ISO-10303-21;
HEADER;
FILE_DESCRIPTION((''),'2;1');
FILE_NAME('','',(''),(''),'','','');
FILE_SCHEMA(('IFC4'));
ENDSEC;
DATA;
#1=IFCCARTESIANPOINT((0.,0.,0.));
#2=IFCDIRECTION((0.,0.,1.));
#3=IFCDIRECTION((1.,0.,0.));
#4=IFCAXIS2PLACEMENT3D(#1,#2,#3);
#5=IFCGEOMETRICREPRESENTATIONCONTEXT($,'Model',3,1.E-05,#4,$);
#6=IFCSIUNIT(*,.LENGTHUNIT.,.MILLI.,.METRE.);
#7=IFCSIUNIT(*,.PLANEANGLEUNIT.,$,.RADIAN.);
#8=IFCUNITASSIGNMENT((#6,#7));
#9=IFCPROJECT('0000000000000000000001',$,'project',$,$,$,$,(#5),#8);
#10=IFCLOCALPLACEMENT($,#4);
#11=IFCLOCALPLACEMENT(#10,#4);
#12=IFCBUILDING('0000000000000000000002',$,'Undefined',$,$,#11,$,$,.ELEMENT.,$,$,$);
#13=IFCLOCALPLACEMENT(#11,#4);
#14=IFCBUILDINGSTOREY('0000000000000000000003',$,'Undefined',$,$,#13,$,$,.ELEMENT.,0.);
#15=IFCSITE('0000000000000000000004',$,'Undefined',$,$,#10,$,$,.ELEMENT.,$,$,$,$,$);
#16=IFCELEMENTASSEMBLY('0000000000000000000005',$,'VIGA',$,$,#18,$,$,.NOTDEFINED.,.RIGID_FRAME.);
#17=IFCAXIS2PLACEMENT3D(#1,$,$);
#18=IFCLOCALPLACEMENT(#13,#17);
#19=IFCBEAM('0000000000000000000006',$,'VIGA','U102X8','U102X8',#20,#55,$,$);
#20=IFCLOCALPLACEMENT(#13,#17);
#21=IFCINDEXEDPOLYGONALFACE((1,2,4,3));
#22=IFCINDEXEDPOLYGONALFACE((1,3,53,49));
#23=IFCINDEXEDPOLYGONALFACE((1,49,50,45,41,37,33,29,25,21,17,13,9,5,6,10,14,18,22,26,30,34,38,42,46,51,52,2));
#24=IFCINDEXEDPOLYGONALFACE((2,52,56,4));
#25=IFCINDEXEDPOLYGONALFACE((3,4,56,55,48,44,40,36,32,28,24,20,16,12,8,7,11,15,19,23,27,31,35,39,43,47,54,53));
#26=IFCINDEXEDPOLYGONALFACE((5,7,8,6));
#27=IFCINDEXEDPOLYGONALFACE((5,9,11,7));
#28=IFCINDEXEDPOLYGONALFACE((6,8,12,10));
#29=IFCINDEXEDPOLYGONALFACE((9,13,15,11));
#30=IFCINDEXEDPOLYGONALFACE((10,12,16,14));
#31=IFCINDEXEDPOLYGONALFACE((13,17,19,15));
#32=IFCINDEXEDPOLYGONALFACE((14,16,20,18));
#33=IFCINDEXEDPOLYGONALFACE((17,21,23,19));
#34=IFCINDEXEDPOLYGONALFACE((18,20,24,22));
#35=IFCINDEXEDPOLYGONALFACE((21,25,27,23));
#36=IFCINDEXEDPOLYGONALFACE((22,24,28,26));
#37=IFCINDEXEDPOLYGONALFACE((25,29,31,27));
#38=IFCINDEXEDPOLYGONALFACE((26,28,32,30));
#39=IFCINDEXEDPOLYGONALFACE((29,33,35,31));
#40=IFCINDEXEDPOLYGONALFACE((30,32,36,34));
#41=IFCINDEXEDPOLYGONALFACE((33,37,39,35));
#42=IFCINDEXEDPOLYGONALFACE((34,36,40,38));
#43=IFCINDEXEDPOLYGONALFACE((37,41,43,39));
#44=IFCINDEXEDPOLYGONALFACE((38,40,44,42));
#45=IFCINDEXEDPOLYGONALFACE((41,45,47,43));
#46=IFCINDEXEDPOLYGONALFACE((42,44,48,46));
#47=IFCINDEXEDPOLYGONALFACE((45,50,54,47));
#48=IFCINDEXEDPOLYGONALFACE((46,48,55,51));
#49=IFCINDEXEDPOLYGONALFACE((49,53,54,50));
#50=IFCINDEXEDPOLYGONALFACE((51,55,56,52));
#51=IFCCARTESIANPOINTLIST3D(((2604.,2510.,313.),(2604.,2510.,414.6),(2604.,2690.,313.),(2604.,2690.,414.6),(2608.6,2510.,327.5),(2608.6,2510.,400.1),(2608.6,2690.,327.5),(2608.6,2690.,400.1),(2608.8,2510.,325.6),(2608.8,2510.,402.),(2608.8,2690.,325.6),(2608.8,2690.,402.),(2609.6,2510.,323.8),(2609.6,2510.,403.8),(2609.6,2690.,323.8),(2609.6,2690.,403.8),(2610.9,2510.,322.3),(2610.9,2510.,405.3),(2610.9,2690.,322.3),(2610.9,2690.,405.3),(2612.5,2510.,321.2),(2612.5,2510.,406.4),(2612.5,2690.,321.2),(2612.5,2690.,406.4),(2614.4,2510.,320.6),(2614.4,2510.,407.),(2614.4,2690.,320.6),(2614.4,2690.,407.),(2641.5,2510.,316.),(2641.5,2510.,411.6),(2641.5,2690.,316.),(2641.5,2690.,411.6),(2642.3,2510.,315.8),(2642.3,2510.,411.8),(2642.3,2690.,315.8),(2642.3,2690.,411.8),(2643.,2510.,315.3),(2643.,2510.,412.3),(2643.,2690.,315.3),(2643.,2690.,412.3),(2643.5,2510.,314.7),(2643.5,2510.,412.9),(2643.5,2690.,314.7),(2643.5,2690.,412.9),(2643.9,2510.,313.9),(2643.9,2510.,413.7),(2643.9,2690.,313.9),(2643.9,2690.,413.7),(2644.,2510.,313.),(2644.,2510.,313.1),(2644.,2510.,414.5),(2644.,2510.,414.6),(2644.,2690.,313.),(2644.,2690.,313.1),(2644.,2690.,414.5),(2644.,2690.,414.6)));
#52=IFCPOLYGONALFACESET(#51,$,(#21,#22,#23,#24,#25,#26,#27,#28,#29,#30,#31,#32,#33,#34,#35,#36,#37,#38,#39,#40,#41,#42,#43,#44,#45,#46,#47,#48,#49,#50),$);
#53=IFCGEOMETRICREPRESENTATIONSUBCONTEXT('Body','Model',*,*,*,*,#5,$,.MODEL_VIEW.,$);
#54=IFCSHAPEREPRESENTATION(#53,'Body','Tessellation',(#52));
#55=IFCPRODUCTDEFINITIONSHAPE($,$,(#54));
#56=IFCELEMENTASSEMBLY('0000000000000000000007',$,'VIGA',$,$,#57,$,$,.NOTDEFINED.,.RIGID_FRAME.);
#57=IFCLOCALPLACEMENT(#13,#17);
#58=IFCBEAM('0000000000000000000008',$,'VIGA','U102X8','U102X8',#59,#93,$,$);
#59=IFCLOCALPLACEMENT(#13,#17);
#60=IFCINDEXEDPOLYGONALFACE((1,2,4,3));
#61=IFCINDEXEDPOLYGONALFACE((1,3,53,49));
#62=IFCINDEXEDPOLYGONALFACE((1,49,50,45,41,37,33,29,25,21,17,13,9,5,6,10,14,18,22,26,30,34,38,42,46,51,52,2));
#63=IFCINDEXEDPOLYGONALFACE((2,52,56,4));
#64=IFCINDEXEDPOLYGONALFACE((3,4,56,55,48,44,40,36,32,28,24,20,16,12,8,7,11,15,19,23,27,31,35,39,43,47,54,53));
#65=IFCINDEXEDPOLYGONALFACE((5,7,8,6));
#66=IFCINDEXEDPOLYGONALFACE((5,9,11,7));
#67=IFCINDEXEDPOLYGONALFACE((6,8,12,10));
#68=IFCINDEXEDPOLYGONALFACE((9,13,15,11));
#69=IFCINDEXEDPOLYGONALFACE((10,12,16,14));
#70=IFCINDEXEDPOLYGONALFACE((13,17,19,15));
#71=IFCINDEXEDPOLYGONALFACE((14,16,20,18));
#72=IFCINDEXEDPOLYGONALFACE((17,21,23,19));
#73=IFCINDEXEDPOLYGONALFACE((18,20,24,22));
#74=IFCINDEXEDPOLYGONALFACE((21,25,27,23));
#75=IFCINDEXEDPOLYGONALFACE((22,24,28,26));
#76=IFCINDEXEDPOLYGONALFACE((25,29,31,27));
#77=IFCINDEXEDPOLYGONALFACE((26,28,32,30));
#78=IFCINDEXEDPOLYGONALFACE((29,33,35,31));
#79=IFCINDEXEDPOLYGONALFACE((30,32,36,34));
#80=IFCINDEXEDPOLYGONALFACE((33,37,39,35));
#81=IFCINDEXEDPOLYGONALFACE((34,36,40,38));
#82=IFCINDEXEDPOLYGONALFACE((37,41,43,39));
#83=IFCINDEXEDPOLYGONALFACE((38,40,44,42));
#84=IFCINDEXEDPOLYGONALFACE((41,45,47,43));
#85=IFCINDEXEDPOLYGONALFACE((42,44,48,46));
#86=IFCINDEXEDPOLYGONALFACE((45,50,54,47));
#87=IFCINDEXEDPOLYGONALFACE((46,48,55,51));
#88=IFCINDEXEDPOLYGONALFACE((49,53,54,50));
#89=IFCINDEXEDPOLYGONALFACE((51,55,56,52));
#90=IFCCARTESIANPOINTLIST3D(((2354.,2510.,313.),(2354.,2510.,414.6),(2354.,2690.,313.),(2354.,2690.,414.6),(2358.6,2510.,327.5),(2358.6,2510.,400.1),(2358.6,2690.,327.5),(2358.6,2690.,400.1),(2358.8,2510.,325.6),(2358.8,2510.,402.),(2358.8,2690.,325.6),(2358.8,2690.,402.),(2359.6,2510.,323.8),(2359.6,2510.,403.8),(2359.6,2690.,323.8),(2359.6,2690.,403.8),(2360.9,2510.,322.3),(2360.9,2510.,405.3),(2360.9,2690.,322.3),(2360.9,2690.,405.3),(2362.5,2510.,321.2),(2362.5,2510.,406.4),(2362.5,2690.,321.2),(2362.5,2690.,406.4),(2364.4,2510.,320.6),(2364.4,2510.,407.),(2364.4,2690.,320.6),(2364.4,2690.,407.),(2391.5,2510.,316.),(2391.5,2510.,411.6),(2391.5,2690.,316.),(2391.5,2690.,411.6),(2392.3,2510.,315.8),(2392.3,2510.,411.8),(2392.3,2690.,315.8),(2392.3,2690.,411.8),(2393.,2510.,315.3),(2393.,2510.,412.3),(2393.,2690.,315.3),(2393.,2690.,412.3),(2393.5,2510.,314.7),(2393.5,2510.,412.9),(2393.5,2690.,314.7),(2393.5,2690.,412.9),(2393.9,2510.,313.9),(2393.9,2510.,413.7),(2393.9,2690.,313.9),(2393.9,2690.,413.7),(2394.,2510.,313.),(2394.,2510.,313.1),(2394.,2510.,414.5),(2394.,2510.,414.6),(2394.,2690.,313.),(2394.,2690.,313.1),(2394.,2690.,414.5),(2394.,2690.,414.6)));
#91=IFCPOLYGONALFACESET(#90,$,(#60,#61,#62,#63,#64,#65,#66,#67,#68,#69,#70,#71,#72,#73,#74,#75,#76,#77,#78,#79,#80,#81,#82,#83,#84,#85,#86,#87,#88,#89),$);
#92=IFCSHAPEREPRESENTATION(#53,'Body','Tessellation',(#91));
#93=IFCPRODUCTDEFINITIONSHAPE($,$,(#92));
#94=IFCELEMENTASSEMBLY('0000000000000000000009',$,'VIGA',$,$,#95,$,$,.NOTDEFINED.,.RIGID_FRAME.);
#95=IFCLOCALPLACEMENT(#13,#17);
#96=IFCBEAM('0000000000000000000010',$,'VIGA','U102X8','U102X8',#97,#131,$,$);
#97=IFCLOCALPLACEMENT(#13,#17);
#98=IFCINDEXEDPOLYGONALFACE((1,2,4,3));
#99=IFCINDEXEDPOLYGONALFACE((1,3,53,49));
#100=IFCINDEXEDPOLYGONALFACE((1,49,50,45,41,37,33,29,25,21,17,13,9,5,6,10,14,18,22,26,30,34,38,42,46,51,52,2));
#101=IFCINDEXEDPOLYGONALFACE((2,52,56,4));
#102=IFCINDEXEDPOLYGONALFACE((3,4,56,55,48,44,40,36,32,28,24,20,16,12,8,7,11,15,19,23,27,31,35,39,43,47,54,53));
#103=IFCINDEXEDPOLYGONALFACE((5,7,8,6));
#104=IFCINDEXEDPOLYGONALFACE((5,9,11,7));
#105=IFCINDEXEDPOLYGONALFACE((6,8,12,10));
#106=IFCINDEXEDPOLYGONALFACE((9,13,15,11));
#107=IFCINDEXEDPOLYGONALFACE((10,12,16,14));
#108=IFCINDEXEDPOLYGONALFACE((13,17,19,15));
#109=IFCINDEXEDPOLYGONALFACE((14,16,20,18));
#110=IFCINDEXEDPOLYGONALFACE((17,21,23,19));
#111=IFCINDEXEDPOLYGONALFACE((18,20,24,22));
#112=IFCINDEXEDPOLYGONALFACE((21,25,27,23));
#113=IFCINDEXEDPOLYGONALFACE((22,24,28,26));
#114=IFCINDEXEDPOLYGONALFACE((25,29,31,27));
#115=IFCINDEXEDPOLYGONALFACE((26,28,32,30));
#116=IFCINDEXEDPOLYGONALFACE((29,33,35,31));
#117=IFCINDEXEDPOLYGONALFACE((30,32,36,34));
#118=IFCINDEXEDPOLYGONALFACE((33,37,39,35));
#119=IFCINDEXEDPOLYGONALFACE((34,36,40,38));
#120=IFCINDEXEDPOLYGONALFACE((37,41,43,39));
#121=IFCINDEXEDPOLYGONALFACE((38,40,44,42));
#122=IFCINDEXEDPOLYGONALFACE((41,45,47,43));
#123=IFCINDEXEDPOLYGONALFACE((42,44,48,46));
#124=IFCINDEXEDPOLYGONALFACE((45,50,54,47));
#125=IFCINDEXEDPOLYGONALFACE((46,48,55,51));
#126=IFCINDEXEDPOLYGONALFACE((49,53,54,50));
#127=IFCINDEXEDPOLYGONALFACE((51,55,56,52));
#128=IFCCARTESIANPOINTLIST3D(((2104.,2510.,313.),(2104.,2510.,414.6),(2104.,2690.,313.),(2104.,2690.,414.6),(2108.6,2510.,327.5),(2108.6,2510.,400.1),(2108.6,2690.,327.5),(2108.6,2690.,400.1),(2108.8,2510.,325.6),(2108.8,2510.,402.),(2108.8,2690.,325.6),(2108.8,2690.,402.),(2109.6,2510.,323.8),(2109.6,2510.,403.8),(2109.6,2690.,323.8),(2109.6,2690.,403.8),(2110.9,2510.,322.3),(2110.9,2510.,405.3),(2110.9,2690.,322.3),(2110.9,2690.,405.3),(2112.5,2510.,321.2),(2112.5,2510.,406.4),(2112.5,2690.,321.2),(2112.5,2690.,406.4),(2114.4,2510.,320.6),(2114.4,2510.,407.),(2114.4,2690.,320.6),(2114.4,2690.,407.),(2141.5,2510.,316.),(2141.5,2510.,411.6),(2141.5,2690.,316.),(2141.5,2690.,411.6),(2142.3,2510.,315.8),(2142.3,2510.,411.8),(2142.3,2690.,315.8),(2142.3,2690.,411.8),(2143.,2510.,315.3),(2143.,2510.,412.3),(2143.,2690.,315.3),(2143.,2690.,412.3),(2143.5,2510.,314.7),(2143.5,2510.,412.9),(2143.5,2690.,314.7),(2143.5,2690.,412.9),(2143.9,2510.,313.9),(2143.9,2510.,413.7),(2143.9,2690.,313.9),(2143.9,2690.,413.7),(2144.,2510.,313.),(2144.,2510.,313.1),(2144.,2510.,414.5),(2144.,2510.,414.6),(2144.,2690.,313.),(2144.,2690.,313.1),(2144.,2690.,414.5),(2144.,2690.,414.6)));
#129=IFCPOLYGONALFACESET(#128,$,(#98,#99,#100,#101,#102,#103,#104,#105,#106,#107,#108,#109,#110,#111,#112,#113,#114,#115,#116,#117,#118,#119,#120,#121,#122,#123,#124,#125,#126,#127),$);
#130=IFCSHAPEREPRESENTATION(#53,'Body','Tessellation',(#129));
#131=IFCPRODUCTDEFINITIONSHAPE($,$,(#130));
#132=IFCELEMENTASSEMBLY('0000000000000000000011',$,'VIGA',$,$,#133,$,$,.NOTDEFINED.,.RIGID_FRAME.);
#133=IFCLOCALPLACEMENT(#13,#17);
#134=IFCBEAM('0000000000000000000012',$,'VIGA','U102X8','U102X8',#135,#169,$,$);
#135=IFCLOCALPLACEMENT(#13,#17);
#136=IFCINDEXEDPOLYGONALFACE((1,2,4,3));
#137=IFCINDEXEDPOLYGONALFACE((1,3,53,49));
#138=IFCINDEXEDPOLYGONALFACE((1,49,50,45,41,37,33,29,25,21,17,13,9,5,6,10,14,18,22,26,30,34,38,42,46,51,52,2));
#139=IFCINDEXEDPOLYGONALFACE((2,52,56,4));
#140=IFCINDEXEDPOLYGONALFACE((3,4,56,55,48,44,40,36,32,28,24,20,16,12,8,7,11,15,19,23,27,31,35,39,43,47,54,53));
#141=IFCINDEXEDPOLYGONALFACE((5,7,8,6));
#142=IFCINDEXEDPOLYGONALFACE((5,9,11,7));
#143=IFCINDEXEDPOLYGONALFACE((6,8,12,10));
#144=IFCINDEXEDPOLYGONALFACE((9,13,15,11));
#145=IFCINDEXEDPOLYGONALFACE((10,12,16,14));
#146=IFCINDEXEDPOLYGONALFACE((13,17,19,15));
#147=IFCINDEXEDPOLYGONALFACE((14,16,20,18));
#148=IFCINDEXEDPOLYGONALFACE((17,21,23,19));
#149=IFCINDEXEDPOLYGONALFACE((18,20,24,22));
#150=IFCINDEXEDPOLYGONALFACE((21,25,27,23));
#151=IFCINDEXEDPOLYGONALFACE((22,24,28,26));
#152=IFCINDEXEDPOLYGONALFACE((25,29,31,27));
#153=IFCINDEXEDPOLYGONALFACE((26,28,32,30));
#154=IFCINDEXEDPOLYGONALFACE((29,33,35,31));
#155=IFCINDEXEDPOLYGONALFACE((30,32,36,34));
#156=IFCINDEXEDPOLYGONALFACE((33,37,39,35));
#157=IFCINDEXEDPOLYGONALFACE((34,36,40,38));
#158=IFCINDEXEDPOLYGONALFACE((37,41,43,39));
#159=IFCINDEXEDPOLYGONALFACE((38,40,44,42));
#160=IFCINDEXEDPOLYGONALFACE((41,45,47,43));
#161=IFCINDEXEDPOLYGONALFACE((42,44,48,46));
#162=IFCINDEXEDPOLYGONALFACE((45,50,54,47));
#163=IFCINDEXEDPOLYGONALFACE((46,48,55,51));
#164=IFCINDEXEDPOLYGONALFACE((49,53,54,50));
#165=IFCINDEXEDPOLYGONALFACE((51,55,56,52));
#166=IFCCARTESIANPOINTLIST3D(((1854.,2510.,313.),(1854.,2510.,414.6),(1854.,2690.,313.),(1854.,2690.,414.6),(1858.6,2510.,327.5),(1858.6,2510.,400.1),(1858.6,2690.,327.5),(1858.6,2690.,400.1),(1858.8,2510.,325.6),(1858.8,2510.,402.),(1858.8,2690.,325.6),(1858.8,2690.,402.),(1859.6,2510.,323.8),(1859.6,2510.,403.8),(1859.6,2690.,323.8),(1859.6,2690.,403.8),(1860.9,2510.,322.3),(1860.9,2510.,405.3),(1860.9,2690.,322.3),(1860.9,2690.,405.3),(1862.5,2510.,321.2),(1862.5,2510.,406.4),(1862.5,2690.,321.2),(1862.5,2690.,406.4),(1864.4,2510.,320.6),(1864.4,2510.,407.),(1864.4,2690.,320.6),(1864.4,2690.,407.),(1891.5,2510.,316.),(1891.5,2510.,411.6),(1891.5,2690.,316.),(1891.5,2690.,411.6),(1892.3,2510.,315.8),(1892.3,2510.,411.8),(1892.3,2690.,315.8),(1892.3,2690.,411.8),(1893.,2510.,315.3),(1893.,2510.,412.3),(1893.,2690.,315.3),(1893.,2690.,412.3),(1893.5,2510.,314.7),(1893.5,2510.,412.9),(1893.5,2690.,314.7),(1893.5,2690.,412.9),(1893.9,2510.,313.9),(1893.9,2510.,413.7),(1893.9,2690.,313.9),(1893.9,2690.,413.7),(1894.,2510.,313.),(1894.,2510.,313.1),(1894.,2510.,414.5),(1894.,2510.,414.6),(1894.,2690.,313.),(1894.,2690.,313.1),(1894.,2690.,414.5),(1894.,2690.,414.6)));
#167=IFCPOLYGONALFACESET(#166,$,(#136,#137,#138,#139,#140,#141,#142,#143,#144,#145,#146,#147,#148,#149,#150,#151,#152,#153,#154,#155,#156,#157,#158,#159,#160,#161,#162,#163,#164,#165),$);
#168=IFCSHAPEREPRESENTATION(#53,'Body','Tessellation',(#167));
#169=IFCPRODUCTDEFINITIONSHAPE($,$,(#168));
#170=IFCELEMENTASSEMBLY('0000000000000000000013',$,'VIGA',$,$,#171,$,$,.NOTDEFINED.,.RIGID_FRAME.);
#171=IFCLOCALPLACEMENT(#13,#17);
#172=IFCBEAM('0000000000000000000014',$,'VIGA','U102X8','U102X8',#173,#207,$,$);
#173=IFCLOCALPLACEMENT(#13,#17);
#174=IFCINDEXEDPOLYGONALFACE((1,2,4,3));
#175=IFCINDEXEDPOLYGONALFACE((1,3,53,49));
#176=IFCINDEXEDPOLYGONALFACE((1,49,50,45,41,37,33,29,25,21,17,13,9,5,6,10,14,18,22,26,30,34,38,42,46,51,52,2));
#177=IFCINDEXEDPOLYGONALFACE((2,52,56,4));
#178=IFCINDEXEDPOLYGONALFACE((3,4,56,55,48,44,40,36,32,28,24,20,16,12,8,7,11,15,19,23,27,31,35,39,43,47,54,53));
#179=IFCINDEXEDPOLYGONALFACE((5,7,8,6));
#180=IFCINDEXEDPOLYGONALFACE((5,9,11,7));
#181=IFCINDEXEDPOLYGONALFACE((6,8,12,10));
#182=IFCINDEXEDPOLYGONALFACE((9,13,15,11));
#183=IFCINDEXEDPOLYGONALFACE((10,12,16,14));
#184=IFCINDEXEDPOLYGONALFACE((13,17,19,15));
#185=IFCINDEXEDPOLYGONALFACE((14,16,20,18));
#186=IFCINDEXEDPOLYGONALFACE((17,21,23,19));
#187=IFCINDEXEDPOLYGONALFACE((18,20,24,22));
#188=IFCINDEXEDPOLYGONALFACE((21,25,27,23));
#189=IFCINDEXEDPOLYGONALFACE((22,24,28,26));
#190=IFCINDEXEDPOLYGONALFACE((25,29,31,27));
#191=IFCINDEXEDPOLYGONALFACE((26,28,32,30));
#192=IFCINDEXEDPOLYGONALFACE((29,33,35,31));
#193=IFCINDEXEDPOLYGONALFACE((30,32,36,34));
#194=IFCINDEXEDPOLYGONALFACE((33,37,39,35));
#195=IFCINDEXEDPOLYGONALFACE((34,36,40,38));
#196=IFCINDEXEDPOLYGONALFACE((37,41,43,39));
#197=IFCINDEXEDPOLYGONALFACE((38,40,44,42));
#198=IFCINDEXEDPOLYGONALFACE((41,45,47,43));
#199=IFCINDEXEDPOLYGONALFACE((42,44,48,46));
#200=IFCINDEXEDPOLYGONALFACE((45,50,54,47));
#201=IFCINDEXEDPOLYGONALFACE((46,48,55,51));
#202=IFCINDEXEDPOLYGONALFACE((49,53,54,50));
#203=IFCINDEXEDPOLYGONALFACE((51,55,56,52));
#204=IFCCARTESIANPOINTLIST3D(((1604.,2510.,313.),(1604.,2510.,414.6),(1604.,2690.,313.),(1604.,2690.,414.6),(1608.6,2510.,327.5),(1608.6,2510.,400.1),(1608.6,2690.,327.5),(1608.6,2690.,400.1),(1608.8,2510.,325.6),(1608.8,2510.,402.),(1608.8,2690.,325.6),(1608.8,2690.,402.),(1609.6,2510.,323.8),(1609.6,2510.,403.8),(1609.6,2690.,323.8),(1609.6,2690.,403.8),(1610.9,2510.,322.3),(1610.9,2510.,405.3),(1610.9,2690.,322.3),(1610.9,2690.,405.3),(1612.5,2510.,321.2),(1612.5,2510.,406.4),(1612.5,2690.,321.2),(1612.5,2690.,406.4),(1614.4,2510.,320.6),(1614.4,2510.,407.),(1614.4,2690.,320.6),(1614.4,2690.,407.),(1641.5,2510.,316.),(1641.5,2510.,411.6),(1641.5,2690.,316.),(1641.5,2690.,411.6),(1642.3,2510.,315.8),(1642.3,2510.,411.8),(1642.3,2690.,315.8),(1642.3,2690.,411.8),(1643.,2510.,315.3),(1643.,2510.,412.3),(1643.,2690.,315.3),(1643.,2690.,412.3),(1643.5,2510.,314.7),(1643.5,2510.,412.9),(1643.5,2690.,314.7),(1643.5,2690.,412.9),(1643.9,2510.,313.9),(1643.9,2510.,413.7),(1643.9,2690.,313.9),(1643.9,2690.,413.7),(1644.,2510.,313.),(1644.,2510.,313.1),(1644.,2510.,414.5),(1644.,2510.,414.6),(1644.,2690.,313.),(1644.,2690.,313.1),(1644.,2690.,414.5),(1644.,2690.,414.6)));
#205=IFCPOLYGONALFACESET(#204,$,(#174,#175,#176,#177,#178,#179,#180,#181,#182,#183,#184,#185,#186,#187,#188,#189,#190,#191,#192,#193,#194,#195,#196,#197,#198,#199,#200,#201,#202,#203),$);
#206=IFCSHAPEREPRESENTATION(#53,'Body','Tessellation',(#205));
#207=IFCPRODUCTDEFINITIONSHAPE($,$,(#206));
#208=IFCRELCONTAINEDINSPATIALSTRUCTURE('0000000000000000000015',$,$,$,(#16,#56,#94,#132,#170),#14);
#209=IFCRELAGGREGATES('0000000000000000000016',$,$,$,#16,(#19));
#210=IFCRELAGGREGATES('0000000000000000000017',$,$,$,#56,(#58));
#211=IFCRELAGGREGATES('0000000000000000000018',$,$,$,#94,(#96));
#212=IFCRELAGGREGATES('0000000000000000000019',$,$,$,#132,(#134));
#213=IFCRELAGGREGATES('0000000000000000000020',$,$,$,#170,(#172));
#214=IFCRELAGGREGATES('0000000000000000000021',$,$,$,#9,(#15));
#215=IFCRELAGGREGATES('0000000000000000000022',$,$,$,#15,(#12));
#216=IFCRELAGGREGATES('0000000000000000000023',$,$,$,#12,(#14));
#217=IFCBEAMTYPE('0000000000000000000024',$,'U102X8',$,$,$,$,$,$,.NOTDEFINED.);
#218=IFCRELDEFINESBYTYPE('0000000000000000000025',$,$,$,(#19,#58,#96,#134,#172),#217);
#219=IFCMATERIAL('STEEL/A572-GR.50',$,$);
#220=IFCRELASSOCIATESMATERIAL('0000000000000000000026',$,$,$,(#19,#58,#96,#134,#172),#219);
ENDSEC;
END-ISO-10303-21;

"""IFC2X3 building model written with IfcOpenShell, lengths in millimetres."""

from ifc_helpers import new_model, si_unit, frame, origin_with_axes, origin_2d_with_axis, place, context, subcontext, project, spatial, u_section, extrude, material, type_object, element, aggregate, save


model = new_model("IFC2X3")

# Units and contexts
model_context = context("Model", 3, precision=1e-05, world=origin_with_axes())
body_context = subcontext(model_context, "Body", "Model", "MODEL_VIEW")
ifc_project = project(units=[si_unit("LENGTHUNIT", "METRE", prefix="MILLI"), si_unit("PLANEANGLEUNIT", "RADIAN")], contexts=[model_context])

# Site, building, storey
site_placement = place(None, origin_with_axes())
site = spatial("IfcSite", under=ifc_project, at=site_placement, Name="Undefined", CompositionType="ELEMENT")
building_placement = place(site_placement, origin_with_axes())
building = spatial("IfcBuilding", under=site, at=building_placement, Name="Undefined", CompositionType="ELEMENT")
storey_placement = place(building_placement, origin_with_axes())
storey = spatial("IfcBuildingStorey", under=building, at=storey_placement, Name="Undefined", CompositionType="ELEMENT", Elevation=0.0)

# Element assemblies, beams
ifc_material = material(Name="STEEL/A572-GR.50")
beam_type = type_object("IfcBeamType", Name="U102X8", PredefinedType="NOTDEFINED")
assembly_1_placement = place(storey_placement, origin_with_axes())
assembly_1 = element("IfcElementAssembly", 1, at=assembly_1_placement, inside=storey, Name="VIGA", AssemblyPlace="NOTDEFINED", PredefinedType="RIGID_FRAME")
beam_1_placement = place(assembly_1_placement, frame((2624.0, 2510.0, 363.8), z_axis=(0.0, 0.0, 1.0), x_axis=(0.0, 1.0, 0.0)))
beam_1 = element("IfcBeam", 2, at=beam_1_placement, type_object=beam_type, material=ifc_material, Name="VIGA", Description="U102X8", ObjectType="U102X8", context=body_context, shape_type="SweptSolid", body=[
    extrude(u_section(Depth=101.6, FlangeWidth=40.0, WebThickness=4.6, FlangeThickness=6.0, FilletRadius=7.0, EdgeRadius=3.0, FlangeSlope=0.16839, at=origin_2d_with_axis()), frame((180.0, 0.0, 0.0), z_axis=(-1.0, 0.0, 0.0), x_axis=(0.0, -1.0, 0.0)), (0.0, 0.0, 1.0), 180.0),
])
aggregate(assembly_1, [beam_1])
assembly_2_placement = place(storey_placement, origin_with_axes())
assembly_2 = element("IfcElementAssembly", 3, at=assembly_2_placement, inside=storey, Name="VIGA", AssemblyPlace="NOTDEFINED", PredefinedType="RIGID_FRAME")
beam_2_placement = place(assembly_2_placement, frame((2374.0, 2510.0, 363.8), z_axis=(0.0, 0.0, 1.0), x_axis=(0.0, 1.0, 0.0)))
beam_2 = element("IfcBeam", 4, at=beam_2_placement, type_object=beam_type, material=ifc_material, Name="VIGA", Description="U102X8", ObjectType="U102X8", context=body_context, shape_type="SweptSolid", body=[
    extrude(u_section(Depth=101.6, FlangeWidth=40.0, WebThickness=4.6, FlangeThickness=6.0, FilletRadius=7.0, EdgeRadius=3.0, FlangeSlope=0.16839, at=origin_2d_with_axis()), frame((180.0, 0.0, 0.0), z_axis=(-1.0, 0.0, 0.0), x_axis=(0.0, -1.0, 0.0)), (0.0, 0.0, 1.0), 180.0),
])
aggregate(assembly_2, [beam_2])
assembly_3_placement = place(storey_placement, origin_with_axes())
assembly_3 = element("IfcElementAssembly", 5, at=assembly_3_placement, inside=storey, Name="VIGA", AssemblyPlace="NOTDEFINED", PredefinedType="RIGID_FRAME")
beam_3_placement = place(assembly_3_placement, frame((2124.0, 2510.0, 363.8), z_axis=(0.0, 0.0, 1.0), x_axis=(0.0, 1.0, 0.0)))
beam_3 = element("IfcBeam", 6, at=beam_3_placement, type_object=beam_type, material=ifc_material, Name="VIGA", Description="U102X8", ObjectType="U102X8", context=body_context, shape_type="SweptSolid", body=[
    extrude(u_section(Depth=101.6, FlangeWidth=40.0, WebThickness=4.6, FlangeThickness=6.0, FilletRadius=7.0, EdgeRadius=3.0, FlangeSlope=0.16839, at=origin_2d_with_axis()), frame((180.0, 0.0, 0.0), z_axis=(-1.0, 0.0, 0.0), x_axis=(0.0, -1.0, 0.0)), (0.0, 0.0, 1.0), 180.0),
])
aggregate(assembly_3, [beam_3])
assembly_4_placement = place(storey_placement, origin_with_axes())
assembly_4 = element("IfcElementAssembly", 7, at=assembly_4_placement, inside=storey, Name="VIGA", AssemblyPlace="NOTDEFINED", PredefinedType="RIGID_FRAME")
beam_4_placement = place(assembly_4_placement, frame((1874.0, 2510.0, 363.8), z_axis=(0.0, 0.0, 1.0), x_axis=(0.0, 1.0, 0.0)))
beam_4 = element("IfcBeam", 8, at=beam_4_placement, type_object=beam_type, material=ifc_material, Name="VIGA", Description="U102X8", ObjectType="U102X8", context=body_context, shape_type="SweptSolid", body=[
    extrude(u_section(Depth=101.6, FlangeWidth=40.0, WebThickness=4.6, FlangeThickness=6.0, FilletRadius=7.0, EdgeRadius=3.0, FlangeSlope=0.16839, at=origin_2d_with_axis()), frame((180.0, 0.0, 0.0), z_axis=(-1.0, 0.0, 0.0), x_axis=(0.0, -1.0, 0.0)), (0.0, 0.0, 1.0), 180.0),
])
aggregate(assembly_4, [beam_4])
assembly_5_placement = place(storey_placement, origin_with_axes())
assembly_5 = element("IfcElementAssembly", 9, at=assembly_5_placement, inside=storey, Name="VIGA", AssemblyPlace="NOTDEFINED", PredefinedType="RIGID_FRAME")
beam_5_placement = place(assembly_5_placement, frame((1624.0, 2510.0, 363.8), z_axis=(0.0, 0.0, 1.0), x_axis=(0.0, 1.0, 0.0)))
beam_5 = element("IfcBeam", 10, at=beam_5_placement, type_object=beam_type, material=ifc_material, Name="VIGA", Description="U102X8", ObjectType="U102X8", context=body_context, shape_type="SweptSolid", body=[
    extrude(u_section(Depth=101.6, FlangeWidth=40.0, WebThickness=4.6, FlangeThickness=6.0, FilletRadius=7.0, EdgeRadius=3.0, FlangeSlope=0.16839, at=origin_2d_with_axis()), frame((180.0, 0.0, 0.0), z_axis=(-1.0, 0.0, 0.0), x_axis=(0.0, -1.0, 0.0)), (0.0, 0.0, 1.0), 180.0),
])
aggregate(assembly_5, [beam_5])

save(model, "model.ifc")
